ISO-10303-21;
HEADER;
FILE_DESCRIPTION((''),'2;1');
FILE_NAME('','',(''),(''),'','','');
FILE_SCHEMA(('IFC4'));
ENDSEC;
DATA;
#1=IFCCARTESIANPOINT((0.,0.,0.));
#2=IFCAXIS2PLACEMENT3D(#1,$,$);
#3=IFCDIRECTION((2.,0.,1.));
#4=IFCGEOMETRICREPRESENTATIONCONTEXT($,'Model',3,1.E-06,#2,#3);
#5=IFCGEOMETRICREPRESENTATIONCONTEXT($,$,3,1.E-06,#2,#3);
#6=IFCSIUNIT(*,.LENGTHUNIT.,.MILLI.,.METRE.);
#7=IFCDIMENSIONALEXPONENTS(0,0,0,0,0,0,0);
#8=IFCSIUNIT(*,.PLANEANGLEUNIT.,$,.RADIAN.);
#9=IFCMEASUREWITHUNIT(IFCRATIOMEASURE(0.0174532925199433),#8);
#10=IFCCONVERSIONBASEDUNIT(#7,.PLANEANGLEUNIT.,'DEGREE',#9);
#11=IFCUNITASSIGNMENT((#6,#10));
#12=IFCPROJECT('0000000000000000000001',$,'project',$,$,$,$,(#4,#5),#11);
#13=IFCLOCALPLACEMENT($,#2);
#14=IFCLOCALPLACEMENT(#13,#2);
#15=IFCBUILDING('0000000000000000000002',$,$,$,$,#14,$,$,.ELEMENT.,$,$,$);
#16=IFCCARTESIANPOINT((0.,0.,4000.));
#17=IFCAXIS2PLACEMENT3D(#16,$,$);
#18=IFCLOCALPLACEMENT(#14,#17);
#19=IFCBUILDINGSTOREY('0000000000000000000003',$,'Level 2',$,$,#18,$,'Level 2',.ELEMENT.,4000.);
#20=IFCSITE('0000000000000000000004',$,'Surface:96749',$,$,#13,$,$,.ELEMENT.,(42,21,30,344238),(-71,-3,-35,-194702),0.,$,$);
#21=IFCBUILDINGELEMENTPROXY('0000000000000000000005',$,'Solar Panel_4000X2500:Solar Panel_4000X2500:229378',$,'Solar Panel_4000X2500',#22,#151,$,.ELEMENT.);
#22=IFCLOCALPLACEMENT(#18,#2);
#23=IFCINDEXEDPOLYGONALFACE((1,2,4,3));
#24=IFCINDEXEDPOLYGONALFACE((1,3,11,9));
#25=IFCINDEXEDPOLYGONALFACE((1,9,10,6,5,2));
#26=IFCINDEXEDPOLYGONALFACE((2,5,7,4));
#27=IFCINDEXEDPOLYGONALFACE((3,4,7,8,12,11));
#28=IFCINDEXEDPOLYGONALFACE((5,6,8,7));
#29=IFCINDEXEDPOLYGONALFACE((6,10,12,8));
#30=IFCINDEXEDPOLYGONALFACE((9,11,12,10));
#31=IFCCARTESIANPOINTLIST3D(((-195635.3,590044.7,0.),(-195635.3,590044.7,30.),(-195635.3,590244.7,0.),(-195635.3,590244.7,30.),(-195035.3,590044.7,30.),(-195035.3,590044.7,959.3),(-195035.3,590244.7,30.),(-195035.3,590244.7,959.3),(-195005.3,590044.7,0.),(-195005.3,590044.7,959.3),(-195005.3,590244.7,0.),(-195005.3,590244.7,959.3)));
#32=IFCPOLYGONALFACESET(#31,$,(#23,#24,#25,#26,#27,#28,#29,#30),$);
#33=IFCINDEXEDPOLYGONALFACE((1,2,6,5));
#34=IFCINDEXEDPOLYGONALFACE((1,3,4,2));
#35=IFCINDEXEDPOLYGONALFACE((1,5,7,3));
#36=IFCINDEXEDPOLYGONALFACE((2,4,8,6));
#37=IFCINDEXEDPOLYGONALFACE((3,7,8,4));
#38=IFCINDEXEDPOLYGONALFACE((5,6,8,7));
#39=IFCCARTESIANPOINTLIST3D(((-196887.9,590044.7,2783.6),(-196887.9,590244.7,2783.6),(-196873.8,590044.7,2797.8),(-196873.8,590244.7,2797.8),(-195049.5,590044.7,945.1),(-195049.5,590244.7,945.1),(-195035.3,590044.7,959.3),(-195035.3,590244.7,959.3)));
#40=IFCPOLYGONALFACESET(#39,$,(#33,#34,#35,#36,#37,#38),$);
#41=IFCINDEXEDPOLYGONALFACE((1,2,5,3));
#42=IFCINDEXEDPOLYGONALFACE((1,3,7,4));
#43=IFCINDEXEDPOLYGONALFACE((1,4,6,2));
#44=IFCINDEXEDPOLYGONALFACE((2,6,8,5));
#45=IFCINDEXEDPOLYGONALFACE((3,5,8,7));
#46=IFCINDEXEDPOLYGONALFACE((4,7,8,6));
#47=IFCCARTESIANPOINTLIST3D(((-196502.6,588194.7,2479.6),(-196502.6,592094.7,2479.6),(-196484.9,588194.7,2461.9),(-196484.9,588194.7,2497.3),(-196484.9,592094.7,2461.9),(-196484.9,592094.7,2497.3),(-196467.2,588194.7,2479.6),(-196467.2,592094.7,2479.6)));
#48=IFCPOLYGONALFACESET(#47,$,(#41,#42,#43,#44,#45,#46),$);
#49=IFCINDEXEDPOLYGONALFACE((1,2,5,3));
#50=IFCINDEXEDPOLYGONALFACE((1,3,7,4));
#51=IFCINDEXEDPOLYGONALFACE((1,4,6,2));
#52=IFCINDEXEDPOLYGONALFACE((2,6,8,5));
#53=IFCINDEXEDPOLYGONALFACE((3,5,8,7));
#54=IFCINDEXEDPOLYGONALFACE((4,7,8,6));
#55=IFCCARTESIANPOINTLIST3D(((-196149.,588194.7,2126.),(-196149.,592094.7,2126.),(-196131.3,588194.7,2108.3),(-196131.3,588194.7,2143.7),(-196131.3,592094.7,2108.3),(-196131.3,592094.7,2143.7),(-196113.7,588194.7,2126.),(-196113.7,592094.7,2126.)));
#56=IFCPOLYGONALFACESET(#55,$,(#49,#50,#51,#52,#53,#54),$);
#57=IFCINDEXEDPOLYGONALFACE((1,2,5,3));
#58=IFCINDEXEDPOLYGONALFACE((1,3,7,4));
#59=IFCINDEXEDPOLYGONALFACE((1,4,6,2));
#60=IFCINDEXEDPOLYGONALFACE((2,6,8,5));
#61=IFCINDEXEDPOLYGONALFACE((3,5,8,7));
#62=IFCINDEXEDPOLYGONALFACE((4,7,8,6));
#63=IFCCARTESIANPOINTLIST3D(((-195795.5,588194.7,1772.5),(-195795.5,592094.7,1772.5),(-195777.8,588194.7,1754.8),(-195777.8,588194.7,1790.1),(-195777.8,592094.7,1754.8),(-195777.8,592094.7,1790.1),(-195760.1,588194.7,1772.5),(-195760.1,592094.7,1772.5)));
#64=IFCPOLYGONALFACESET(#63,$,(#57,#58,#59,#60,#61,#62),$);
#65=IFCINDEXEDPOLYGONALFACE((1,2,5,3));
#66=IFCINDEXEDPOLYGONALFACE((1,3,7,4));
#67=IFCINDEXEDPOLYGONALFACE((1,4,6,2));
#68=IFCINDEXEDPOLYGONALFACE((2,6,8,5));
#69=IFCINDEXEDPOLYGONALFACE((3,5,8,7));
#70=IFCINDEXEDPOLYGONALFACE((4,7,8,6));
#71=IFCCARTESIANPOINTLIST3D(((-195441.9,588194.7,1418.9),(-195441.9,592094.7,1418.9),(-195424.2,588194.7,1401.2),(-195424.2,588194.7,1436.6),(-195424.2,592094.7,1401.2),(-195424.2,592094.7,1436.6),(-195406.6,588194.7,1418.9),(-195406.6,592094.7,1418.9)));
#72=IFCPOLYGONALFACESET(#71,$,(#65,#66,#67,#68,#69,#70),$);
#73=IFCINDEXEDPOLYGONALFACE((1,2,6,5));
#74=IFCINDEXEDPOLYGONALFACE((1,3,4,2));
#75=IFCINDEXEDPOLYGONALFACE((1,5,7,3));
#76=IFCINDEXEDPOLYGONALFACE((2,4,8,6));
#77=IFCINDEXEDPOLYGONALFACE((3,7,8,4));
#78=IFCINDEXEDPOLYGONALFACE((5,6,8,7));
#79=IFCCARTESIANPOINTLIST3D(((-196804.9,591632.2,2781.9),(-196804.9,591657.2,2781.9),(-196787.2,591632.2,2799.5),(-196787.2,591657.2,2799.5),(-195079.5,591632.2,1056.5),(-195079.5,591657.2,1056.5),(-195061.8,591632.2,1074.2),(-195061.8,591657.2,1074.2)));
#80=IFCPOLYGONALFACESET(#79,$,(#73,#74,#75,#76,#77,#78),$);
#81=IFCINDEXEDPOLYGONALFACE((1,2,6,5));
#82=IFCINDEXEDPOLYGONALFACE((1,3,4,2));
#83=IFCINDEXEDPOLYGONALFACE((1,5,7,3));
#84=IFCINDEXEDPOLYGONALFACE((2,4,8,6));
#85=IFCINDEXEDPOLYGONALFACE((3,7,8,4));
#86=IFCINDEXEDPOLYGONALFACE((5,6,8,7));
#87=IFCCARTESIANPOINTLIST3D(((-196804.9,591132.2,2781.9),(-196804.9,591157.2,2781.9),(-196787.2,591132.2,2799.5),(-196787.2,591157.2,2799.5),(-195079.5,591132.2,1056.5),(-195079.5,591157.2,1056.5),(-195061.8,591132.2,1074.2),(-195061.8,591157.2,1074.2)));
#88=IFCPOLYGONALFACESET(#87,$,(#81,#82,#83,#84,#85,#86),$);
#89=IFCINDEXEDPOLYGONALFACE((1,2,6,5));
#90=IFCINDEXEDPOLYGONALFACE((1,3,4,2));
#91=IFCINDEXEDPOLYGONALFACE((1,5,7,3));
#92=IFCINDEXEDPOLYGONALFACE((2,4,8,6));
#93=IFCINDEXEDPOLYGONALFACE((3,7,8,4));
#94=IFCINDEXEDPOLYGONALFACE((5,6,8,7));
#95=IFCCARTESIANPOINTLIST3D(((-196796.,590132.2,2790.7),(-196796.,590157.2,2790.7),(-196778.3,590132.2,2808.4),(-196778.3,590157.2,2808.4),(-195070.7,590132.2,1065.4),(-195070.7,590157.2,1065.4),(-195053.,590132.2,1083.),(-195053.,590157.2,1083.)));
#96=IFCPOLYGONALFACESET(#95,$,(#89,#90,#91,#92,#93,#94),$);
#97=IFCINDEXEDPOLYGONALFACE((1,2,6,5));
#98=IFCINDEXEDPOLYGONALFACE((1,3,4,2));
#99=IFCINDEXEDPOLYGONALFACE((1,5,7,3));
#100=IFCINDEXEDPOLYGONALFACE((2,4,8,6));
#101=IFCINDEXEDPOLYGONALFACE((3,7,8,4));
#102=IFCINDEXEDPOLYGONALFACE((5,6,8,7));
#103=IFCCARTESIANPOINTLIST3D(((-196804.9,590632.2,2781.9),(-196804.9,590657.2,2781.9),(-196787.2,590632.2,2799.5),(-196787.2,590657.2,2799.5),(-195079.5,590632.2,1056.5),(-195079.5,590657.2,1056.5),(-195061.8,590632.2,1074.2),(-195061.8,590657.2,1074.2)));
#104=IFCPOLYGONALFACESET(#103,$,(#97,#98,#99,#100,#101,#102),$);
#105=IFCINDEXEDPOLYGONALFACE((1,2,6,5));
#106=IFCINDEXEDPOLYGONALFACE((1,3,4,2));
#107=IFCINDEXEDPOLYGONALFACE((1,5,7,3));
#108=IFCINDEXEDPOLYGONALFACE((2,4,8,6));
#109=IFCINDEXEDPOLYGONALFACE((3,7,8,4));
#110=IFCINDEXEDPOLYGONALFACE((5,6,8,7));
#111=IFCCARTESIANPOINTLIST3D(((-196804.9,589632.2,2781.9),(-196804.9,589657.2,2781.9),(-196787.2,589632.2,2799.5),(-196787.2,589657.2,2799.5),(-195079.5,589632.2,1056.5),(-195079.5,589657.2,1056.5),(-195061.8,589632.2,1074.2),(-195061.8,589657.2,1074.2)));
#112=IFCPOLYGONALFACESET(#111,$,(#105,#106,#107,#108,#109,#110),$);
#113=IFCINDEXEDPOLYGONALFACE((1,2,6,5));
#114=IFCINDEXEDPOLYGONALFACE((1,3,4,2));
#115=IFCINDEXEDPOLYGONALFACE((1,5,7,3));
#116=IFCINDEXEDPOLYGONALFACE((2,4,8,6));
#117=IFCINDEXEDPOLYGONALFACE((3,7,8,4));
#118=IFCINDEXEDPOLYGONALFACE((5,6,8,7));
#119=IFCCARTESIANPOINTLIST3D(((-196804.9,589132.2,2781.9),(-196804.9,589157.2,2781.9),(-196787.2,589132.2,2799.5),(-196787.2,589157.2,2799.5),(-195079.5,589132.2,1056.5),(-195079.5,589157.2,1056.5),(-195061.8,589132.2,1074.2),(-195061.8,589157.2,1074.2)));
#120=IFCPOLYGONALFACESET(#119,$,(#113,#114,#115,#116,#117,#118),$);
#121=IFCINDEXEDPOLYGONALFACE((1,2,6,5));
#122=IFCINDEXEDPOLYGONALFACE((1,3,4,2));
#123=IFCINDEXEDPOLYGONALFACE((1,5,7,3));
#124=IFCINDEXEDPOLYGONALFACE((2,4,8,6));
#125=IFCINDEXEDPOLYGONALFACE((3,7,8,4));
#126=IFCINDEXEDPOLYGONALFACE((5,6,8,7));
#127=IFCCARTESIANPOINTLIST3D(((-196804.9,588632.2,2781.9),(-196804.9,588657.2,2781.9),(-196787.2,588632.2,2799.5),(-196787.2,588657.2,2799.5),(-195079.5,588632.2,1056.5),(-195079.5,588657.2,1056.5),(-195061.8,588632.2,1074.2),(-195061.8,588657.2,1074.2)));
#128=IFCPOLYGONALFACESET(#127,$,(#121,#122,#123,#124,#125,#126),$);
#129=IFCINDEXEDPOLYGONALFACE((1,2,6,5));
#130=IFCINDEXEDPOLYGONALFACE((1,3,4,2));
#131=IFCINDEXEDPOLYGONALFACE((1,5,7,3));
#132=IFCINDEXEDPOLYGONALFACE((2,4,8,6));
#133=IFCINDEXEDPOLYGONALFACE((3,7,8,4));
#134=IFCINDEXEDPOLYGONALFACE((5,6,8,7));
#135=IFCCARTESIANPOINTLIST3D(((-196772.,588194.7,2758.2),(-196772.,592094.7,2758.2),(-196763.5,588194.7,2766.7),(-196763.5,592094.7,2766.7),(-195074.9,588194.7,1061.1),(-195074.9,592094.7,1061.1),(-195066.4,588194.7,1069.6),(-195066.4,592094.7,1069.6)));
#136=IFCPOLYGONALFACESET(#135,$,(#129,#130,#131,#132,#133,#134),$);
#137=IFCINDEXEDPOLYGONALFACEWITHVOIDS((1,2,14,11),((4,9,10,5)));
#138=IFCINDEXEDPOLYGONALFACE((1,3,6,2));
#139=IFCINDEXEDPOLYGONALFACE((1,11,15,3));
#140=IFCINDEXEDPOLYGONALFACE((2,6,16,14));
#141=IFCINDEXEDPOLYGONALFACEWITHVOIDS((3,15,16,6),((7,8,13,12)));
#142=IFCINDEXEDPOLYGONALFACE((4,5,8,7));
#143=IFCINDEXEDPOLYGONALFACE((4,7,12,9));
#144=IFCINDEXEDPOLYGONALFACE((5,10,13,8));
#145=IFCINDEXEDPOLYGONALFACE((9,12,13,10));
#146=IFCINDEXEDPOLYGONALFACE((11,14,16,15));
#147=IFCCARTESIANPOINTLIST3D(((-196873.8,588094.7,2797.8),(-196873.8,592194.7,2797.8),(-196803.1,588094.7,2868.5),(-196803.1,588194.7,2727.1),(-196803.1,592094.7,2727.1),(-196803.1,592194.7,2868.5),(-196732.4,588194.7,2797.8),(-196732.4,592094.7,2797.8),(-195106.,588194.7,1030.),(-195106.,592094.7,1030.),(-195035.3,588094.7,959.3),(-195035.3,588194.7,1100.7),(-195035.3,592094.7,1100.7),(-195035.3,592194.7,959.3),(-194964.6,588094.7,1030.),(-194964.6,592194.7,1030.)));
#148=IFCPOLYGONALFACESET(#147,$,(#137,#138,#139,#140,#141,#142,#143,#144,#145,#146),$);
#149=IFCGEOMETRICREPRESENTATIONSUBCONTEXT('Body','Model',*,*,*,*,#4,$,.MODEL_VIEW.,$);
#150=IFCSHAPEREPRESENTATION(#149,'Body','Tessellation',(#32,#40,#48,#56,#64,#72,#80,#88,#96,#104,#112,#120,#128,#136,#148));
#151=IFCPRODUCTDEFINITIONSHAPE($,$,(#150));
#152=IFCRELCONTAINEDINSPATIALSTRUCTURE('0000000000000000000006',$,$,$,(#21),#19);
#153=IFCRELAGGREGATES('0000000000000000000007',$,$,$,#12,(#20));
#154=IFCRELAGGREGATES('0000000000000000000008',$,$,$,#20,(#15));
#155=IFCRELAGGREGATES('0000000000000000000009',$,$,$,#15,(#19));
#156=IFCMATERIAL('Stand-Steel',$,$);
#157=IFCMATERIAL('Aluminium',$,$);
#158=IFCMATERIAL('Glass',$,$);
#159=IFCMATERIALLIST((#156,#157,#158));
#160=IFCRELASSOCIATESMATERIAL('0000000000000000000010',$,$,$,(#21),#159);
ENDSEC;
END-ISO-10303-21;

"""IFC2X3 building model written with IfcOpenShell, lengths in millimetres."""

from ifc_helpers import new_model, entity, si_unit, converted_unit, direction, frame, frame_2d, origin, origin_2d_with_axis, place, context, subcontext, project, spatial, polyline, rectangle, outline, extrude, source, transform, mapped, material, material_list, element, save


model = new_model("IFC2X3")

# Units and contexts
model_context = context("Model", 3, precision=1e-06, world=origin(), true_north=direction((2.0, 0.0, 1.0)))
context_of_model = context(None, 3, precision=1e-06, world=origin(), true_north=direction((2.0, 0.0, 1.0)))
body_context = subcontext(model_context, "Body", "Model", "MODEL_VIEW")
ifc_project = project(units=[si_unit("LENGTHUNIT", "METRE", prefix="MILLI"), converted_unit("PLANEANGLEUNIT", "DEGREE", entity("IfcRatioMeasure", 0.0174532925199433), si_unit("PLANEANGLEUNIT", "RADIAN"), dimensions=[0, 0, 0, 0, 0, 0, 0])], contexts=[model_context, context_of_model])

# Site, building, storey
site_placement = place(None, origin())
site = spatial("IfcSite", under=ifc_project, at=site_placement, Name="Surface:96749", CompositionType="ELEMENT", RefLatitude=(42, 21, 30, 344238), RefLongitude=(-71, -3, -35, -194702), RefElevation=0.0)
building_placement = place(site_placement, origin())
building = spatial("IfcBuilding", under=site, at=building_placement, CompositionType="ELEMENT")
storey_placement = place(building_placement, frame((0.0, 0.0, 4000.0)))
storey = spatial("IfcBuildingStorey", under=building, at=storey_placement, Name="Level 2", LongName="Level 2", CompositionType="ELEMENT", Elevation=4000.0)

# Building element proxy
ifc_material_1 = material(Name="Stand-Steel")
ifc_material_2 = material(Name="Aluminium")
ifc_material_3 = material(Name="Glass")
shared_shape = source(origin(), body_context, "Body", "SweptSolid", [
    extrude(outline(polyline([(-629.5, -220.0), (329.8, -220.0), (329.8, 410.0), (299.8, 410.0), (299.8, -190.0), (-629.5, -190.0), (-629.5, -220.0)])), frame((-190.0, -100.0, 299.8), z_axis=(0.0, 1.0, 0.0), x_axis=(0.0, 0.0, -1.0)), (0.0, 0.0, 1.0), 200.0),
    extrude(rectangle(XDim=20.0, YDim=200.0, at=frame_2d((0.0, 0.0), x_axis=(0.0, 1.0))), frame((-7.1, 0.0, 922.2), z_axis=(-0.707107, 0.0, 0.707107), x_axis=(0.0, 1.0, 0.0)), (0.0, 0.0, 1.0), 2600.0),
    extrude(rectangle(XDim=25.0, YDim=25.0, at=frame_2d((0.0, 0.0), x_axis=(1.0, 0.0))), frame((-1449.6, -1950.0, 2449.6), z_axis=(0.0, 1.0, 0.0), x_axis=(-0.707107, 0.0, -0.707107)), (0.0, 0.0, 1.0), 3900.0),
    extrude(rectangle(XDim=25.0, YDim=25.0, at=origin_2d_with_axis()), frame((-1096.0, -1950.0, 2096.0), z_axis=(0.0, 1.0, 0.0), x_axis=(-0.707107, 0.0, -0.707107)), (0.0, 0.0, 1.0), 3900.0),
    extrude(rectangle(XDim=25.0, YDim=25.0, at=origin_2d_with_axis()), frame((-742.5, -1950.0, 1742.5), z_axis=(0.0, 1.0, 0.0), x_axis=(-0.707107, 0.0, -0.707107)), (0.0, 0.0, 1.0), 3900.0),
    extrude(rectangle(XDim=25.0, YDim=25.0, at=frame_2d((0.0, 0.0), x_axis=(1.0, 0.0))), frame((-388.9, -1950.0, 1388.9), z_axis=(0.0, 1.0, 0.0), x_axis=(-0.707107, 0.0, -0.707107)), (0.0, 0.0, 1.0), 3900.0),
    extrude(rectangle(XDim=25.0, YDim=25.0, at=frame_2d((0.0, 0.0), x_axis=(0.0, 1.0))), frame((-35.4, 1500.0, 1035.4), z_axis=(-0.707107, 0.0, 0.707107), x_axis=(0.0, 1.0, 0.0)), (0.0, 0.0, 1.0), 2440.0),
    extrude(rectangle(XDim=25.0, YDim=25.0, at=frame_2d((0.0, 0.0), x_axis=(0.0, 1.0))), frame((-35.4, 1000.0, 1035.4), z_axis=(-0.707107, 0.0, 0.707107), x_axis=(0.0, 1.0, 0.0)), (0.0, 0.0, 1.0), 2440.0),
    extrude(rectangle(XDim=25.0, YDim=25.0, at=frame_2d((0.0, 0.0), x_axis=(0.0, 1.0))), frame((-26.5, 0.0, 1044.2), z_axis=(-0.707107, 0.0, 0.707107), x_axis=(0.0, -1.0, 0.0)), (0.0, 0.0, 1.0), 2440.0),
    extrude(rectangle(XDim=25.0, YDim=25.0, at=frame_2d((0.0, 0.0), x_axis=(0.0, 1.0))), frame((-35.4, 500.0, 1035.4), z_axis=(-0.707107, 0.0, 0.707107), x_axis=(0.0, 1.0, 0.0)), (0.0, 0.0, 1.0), 2440.0),
    extrude(rectangle(XDim=25.0, YDim=25.0, at=frame_2d((0.0, 0.0), x_axis=(0.0, 1.0))), frame((-35.4, -500.0, 1035.4), z_axis=(-0.707107, 0.0, 0.707107), x_axis=(0.0, 1.0, 0.0)), (0.0, 0.0, 1.0), 2440.0),
    extrude(rectangle(XDim=25.0, YDim=25.0, at=frame_2d((0.0, 0.0), x_axis=(0.0, 1.0))), frame((-35.4, -1000.0, 1035.4), z_axis=(-0.707107, 0.0, 0.707107), x_axis=(0.0, 1.0, 0.0)), (0.0, 0.0, 1.0), 2440.0),
    extrude(rectangle(XDim=25.0, YDim=25.0, at=frame_2d((0.0, 0.0), x_axis=(0.0, 1.0))), frame((-35.4, -1500.0, 1035.4), z_axis=(-0.707107, 0.0, 0.707107), x_axis=(0.0, 1.0, 0.0)), (0.0, 0.0, 1.0), 2440.0),
    extrude(rectangle(XDim=2400.0, YDim=12.0, at=frame_2d((0.0, 0.0), x_axis=(1.0, 0.0))), frame((-883.9, -1950.0, 1883.9), z_axis=(0.0, 1.0, 0.0), x_axis=(0.707107, 0.0, -0.707107)), (0.0, 0.0, 1.0), 3900.0),
    extrude(outline(polyline([(-2050.0, -1300.0), (2050.0, -1300.0), (2050.0, 1300.0), (-2050.0, 1300.0), (-2050.0, -1300.0)]), holes=[polyline([(1950.0, -1200.0), (-1950.0, -1200.0), (-1950.0, 1200.0), (1950.0, 1200.0), (1950.0, -1200.0)])]), frame((-919.2, 0.0, 1848.5), z_axis=(0.707107, 0.0, 0.707107), x_axis=(0.0, 1.0, 0.0)), (0.0, 0.0, 1.0), 100.0),
])
ifc_material_list_1 = material_list([ifc_material_1, ifc_material_2, ifc_material_3])
proxy_1_placement = place(storey_placement, frame((-195035.3, 590144.7, 30.0)))
element("IfcBuildingElementProxy", 1, at=proxy_1_placement, inside=storey, material=ifc_material_list_1, Name="Solar Panel_4000X2500:Solar Panel_4000X2500:229378", ObjectType="Solar Panel_4000X2500", CompositionType="ELEMENT", context=body_context, shape_type="MappedRepresentation", body=[
    mapped(shared_shape, transform((0.0, 0.0, 0.0), scale=1.0)),
])

save(model, "model.ifc")
